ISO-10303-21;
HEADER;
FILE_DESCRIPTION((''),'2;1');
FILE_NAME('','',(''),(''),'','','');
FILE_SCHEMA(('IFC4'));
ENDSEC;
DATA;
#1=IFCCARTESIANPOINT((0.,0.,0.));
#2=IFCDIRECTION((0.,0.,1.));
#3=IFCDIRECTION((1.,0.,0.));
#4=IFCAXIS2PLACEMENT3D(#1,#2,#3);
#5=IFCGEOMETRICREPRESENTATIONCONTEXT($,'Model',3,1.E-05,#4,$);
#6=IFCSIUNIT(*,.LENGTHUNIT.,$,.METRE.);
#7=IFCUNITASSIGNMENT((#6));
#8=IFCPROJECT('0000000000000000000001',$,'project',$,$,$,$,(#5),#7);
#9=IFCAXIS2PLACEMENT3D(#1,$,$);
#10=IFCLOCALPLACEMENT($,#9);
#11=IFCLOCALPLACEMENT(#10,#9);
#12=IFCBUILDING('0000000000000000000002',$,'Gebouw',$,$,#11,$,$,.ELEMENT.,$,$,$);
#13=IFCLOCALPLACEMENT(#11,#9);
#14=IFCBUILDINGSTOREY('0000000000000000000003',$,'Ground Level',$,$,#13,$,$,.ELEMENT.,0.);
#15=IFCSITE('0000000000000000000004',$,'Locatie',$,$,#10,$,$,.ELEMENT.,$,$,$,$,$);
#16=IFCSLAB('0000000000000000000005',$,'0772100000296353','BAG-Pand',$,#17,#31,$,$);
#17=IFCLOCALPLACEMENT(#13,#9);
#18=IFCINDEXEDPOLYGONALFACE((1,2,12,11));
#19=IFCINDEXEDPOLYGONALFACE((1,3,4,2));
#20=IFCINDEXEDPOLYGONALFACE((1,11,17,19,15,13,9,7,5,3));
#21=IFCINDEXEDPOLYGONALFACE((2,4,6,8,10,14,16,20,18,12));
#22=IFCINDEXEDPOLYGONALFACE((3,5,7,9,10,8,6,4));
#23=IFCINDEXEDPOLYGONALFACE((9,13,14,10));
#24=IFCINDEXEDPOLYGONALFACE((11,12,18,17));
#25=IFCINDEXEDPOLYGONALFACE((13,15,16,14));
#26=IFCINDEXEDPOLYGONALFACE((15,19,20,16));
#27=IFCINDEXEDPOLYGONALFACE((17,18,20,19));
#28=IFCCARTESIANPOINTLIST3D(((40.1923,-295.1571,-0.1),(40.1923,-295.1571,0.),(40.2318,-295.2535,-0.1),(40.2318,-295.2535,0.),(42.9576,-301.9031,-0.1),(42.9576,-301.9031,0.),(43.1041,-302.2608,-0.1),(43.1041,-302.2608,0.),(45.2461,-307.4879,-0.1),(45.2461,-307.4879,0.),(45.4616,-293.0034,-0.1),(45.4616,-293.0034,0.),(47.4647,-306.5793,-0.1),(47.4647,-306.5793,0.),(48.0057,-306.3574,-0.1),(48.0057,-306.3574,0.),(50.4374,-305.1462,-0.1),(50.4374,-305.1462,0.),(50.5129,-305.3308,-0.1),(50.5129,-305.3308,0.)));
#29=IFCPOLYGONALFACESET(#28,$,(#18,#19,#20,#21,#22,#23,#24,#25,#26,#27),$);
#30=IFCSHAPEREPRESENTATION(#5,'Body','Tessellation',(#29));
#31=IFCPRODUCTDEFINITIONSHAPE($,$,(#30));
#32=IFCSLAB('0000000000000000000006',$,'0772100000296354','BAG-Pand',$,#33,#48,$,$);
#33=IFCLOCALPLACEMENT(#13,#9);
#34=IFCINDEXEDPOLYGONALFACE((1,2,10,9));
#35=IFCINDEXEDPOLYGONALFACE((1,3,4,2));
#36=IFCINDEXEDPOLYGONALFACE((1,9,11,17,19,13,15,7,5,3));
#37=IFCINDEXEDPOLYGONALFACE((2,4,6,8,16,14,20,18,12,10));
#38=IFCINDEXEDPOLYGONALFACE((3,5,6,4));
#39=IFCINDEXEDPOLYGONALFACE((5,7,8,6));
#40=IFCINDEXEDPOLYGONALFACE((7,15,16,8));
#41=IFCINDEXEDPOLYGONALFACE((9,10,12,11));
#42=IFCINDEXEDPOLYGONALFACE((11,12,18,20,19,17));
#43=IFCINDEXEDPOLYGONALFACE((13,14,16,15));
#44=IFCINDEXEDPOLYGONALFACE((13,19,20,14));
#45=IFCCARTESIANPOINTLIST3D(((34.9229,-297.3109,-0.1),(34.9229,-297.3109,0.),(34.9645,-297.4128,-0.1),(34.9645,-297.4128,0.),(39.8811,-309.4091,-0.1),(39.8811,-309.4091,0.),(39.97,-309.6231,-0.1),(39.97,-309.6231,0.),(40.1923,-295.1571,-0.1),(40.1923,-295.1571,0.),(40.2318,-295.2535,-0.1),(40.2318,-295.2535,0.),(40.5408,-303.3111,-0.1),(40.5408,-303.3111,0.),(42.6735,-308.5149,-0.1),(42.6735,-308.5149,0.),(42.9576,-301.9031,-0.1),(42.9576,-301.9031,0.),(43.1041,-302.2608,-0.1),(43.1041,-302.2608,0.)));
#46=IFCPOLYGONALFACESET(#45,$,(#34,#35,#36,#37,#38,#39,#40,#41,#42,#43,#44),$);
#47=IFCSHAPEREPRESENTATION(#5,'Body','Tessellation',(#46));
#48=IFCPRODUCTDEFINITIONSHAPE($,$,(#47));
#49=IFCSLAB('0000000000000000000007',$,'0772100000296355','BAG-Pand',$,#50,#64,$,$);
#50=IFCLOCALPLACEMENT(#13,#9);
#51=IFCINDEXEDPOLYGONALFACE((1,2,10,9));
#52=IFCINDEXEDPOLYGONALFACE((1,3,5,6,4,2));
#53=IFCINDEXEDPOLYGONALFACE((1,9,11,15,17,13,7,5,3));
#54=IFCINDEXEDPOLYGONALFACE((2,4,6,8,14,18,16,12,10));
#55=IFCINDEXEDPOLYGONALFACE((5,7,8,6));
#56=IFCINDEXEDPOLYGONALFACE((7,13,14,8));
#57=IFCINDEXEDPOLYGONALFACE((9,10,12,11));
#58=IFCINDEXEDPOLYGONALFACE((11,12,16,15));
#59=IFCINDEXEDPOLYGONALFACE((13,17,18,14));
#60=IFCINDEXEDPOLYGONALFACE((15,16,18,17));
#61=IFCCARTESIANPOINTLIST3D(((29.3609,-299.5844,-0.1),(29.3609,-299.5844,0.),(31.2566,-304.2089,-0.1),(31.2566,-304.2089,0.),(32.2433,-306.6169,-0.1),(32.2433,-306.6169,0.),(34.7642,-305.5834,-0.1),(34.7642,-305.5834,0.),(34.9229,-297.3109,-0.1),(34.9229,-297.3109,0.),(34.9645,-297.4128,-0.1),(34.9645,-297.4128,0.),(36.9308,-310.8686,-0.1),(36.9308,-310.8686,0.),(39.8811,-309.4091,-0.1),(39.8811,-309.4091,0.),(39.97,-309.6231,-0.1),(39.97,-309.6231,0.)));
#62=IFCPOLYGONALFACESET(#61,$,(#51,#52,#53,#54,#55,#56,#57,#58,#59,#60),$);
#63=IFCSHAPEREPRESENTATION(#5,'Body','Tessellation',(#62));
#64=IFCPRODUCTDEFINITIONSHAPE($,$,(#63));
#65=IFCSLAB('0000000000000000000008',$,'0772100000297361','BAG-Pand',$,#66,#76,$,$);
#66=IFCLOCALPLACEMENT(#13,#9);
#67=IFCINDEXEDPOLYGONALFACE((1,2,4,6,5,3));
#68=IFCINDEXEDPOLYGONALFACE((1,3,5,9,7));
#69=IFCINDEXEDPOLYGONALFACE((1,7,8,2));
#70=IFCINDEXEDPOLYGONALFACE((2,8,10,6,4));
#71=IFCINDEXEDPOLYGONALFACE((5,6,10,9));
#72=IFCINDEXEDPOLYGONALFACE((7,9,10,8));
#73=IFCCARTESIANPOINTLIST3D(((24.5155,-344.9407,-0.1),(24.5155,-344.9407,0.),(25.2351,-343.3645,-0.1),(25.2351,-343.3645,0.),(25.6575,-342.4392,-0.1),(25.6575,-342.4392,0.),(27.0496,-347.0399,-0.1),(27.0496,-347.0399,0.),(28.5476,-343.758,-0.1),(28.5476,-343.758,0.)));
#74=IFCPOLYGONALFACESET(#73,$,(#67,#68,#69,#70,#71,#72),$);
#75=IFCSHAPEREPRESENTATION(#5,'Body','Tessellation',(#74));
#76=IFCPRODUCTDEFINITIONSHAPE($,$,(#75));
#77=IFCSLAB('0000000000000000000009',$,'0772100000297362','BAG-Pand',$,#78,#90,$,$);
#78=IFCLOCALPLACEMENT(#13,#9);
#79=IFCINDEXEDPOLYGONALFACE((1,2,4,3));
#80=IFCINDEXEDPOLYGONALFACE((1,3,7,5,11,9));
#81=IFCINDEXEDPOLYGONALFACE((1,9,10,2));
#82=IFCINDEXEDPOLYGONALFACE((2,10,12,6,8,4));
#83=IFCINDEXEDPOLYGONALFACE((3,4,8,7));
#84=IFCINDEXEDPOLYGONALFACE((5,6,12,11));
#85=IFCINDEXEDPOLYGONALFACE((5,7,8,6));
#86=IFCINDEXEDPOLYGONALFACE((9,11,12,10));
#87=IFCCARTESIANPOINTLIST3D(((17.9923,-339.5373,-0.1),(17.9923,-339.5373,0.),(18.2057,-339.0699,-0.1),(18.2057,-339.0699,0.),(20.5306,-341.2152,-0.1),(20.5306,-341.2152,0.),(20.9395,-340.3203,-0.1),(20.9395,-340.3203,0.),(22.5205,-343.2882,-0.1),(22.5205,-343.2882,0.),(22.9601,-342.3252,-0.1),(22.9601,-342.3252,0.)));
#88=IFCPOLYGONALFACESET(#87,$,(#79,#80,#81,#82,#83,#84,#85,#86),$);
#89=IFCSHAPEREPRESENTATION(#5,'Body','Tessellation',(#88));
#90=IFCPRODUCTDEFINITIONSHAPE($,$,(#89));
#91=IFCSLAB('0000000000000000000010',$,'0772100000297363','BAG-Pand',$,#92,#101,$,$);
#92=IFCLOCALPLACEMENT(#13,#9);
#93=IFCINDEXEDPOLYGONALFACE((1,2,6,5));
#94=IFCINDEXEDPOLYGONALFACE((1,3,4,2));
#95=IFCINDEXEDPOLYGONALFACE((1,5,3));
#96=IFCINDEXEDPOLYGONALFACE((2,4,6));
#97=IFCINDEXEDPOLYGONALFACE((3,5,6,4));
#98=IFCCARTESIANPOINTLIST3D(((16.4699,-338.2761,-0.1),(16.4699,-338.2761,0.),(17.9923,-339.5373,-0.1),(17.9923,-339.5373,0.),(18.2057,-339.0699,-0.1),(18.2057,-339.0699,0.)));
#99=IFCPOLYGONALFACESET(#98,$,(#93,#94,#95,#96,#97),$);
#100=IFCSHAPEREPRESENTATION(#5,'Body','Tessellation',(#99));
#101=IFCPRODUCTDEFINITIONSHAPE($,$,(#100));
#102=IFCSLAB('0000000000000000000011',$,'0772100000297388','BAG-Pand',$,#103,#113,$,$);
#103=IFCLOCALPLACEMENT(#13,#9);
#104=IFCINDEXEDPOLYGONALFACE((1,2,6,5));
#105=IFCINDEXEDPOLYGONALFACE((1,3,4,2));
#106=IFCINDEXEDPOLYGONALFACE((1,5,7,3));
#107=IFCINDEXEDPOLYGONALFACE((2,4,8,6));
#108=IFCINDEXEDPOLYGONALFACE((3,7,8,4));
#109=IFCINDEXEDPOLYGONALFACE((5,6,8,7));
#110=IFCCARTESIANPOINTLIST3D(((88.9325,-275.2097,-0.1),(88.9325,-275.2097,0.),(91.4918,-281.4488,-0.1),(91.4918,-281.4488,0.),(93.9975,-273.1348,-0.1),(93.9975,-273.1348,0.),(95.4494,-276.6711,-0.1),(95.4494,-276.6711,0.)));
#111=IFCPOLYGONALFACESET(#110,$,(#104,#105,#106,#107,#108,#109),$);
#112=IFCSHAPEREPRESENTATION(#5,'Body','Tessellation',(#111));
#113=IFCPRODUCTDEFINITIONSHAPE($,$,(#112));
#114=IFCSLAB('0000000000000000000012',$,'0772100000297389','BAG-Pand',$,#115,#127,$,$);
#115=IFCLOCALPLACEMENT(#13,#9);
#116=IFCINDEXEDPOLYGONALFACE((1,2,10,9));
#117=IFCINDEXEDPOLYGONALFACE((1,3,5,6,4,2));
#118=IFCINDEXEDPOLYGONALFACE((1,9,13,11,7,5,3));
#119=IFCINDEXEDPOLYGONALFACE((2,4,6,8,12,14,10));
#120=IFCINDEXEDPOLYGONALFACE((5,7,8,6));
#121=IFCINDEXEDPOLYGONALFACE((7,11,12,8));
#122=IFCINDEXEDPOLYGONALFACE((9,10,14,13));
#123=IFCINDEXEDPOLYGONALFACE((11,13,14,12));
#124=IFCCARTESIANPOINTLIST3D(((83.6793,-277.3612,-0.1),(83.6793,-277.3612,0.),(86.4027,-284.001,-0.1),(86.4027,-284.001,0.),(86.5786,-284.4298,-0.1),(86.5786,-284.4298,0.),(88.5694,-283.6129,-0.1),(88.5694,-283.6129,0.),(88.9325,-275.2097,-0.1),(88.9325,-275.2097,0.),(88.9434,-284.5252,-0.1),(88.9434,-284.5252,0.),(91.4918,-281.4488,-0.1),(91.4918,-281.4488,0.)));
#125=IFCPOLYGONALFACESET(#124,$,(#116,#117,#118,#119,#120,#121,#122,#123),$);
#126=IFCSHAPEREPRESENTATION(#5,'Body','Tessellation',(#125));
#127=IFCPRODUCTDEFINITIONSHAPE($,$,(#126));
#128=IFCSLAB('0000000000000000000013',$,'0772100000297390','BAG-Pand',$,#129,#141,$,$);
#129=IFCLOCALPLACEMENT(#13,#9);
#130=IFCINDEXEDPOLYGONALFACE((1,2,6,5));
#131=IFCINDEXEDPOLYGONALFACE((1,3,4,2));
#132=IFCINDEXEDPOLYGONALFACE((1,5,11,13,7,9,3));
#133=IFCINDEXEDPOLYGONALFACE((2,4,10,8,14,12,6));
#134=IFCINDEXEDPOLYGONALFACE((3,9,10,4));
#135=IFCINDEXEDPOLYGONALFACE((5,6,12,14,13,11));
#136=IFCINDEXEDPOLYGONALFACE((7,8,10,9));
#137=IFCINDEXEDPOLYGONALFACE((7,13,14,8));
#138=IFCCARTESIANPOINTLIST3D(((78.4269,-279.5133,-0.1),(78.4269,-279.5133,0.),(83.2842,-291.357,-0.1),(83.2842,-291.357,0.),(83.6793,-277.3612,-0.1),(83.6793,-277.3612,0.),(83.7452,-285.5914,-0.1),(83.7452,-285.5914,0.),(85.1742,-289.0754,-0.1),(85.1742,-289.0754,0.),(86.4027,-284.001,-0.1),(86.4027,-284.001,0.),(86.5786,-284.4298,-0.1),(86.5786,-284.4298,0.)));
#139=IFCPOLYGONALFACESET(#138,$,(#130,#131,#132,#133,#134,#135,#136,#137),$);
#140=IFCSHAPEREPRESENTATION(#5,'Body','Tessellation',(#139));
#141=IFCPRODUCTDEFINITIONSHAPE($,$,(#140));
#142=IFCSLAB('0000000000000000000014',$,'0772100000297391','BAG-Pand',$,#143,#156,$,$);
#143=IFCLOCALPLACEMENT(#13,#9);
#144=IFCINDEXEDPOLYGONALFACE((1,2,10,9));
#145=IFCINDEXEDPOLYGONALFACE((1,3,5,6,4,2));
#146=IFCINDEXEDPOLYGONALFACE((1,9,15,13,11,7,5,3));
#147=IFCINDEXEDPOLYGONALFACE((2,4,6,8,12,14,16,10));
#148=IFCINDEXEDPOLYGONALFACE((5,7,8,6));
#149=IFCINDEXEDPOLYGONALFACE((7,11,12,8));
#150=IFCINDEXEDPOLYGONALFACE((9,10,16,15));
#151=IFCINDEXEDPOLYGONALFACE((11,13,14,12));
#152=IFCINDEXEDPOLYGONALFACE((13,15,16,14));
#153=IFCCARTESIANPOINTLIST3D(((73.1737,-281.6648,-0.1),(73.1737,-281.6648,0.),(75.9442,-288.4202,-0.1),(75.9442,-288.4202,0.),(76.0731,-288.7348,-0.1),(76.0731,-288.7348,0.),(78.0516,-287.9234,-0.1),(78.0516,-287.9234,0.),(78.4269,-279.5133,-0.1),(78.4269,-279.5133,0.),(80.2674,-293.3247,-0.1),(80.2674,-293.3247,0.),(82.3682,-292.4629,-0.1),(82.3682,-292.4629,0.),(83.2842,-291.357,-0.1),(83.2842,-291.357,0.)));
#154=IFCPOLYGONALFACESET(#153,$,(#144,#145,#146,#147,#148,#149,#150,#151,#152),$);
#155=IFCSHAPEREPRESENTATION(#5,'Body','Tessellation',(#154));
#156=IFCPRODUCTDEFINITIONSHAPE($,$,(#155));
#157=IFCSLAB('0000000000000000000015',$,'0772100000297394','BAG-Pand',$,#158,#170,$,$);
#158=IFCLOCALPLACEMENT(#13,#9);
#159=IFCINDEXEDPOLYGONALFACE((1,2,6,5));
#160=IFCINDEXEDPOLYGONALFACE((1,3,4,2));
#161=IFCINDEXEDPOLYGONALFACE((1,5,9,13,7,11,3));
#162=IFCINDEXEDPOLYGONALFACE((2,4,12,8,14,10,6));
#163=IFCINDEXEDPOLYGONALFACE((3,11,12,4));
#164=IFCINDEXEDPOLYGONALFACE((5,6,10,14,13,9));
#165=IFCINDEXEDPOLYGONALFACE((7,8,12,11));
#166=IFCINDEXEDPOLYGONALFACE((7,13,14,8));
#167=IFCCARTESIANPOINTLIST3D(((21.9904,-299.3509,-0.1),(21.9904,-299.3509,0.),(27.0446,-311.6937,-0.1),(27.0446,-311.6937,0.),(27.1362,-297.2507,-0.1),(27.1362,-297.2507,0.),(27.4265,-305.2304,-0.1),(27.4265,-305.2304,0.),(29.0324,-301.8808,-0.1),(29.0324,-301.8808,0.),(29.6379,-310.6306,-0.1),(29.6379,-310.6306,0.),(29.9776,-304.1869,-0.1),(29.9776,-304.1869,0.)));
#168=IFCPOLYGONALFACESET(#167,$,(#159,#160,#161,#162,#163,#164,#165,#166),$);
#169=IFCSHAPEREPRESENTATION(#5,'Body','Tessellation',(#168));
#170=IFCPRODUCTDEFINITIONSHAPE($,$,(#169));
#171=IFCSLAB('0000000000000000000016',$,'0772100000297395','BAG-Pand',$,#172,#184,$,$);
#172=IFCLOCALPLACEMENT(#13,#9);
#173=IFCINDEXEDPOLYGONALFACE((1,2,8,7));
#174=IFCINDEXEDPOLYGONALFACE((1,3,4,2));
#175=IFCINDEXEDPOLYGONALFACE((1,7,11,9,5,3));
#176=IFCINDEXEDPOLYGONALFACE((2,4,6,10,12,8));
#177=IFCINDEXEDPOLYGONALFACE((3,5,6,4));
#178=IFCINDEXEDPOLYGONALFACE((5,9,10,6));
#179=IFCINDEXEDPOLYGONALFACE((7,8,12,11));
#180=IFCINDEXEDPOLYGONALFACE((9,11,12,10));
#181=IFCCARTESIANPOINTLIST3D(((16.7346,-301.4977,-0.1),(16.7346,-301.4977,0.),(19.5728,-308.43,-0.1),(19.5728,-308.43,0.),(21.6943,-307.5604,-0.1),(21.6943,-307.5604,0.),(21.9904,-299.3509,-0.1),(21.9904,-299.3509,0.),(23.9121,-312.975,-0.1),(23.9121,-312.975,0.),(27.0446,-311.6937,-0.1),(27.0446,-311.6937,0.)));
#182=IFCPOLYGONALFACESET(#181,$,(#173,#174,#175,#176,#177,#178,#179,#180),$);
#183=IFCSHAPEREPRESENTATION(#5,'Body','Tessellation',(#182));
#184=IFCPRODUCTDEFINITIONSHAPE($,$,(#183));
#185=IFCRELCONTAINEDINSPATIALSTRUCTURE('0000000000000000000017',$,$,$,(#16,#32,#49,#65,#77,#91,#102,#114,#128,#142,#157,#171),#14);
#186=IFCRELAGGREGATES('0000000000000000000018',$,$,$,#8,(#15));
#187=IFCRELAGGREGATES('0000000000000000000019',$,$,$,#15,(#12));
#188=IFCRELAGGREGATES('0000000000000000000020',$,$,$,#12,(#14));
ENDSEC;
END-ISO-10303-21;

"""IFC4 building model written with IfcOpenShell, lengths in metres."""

from ifc_helpers import new_model, si_unit, frame, origin, origin_with_axes, place, context, project, spatial, polyline, outline, extrude, element, save


model = new_model("IFC4")

# Units and contexts
model_context = context("Model", 3, precision=1e-05, world=origin_with_axes())
ifc_project = project(units=[si_unit("LENGTHUNIT", "METRE")], contexts=[model_context])

# Site, building, storey
site_placement = place(None, origin())
site = spatial("IfcSite", under=ifc_project, at=site_placement, Name="Locatie", CompositionType="ELEMENT")
building_placement = place(site_placement, origin())
building = spatial("IfcBuilding", under=site, at=building_placement, Name="Gebouw", CompositionType="ELEMENT")
storey_placement = place(building_placement, origin())
storey = spatial("IfcBuildingStorey", under=building, at=storey_placement, Name="Ground Level", CompositionType="ELEMENT", Elevation=0.0)

# Slabs
slab_1_placement = place(storey_placement, origin())
element("IfcSlab", 1, at=slab_1_placement, inside=storey, Name="0772100000296353", Description="BAG-Pand", context=model_context, shape_type="SweptSolid", body=[
    extrude(outline(polyline([(43.1041, -302.2608), (42.9576, -301.9031), (40.2318, -295.2535), (40.1923, -295.1571), (45.4616, -293.0034), (50.4374, -305.1462), (50.5129, -305.3308), (48.0057, -306.3574), (47.4647, -306.5793), (45.2461, -307.4879), (43.1041, -302.2608)])), frame((0.0, 0.0, -0.1), z_axis=(0.0, 0.0, 1.0), x_axis=(1.0, 0.0, 0.0)), (0.0, 0.0, 1.0), 0.1),
])
slab_2_placement = place(storey_placement, origin())
element("IfcSlab", 2, at=slab_2_placement, inside=storey, Name="0772100000296354", Description="BAG-Pand", context=model_context, shape_type="SweptSolid", body=[
    extrude(outline(polyline([(39.97, -309.6231), (39.8811, -309.4091), (34.9645, -297.4128), (34.9229, -297.3109), (40.1923, -295.1571), (40.2318, -295.2535), (42.9576, -301.9031), (43.1041, -302.2608), (40.5408, -303.3111), (42.6735, -308.5149), (39.97, -309.6231)])), frame((0.0, 0.0, -0.1), z_axis=(0.0, 0.0, 1.0), x_axis=(1.0, 0.0, 0.0)), (0.0, 0.0, 1.0), 0.1),
])
slab_3_placement = place(storey_placement, origin())
element("IfcSlab", 3, at=slab_3_placement, inside=storey, Name="0772100000296355", Description="BAG-Pand", context=model_context, shape_type="SweptSolid", body=[
    extrude(outline(polyline([(34.9229, -297.3109), (34.9645, -297.4128), (39.8811, -309.4091), (39.97, -309.6231), (36.9308, -310.8686), (34.7642, -305.5834), (32.2433, -306.6169), (31.2566, -304.2089), (29.3609, -299.5844), (34.9229, -297.3109)])), frame((0.0, 0.0, -0.1), z_axis=(0.0, 0.0, 1.0), x_axis=(1.0, 0.0, 0.0)), (0.0, 0.0, 1.0), 0.1),
])
slab_4_placement = place(storey_placement, origin())
element("IfcSlab", 4, at=slab_4_placement, inside=storey, Name="0772100000297361", Description="BAG-Pand", context=model_context, shape_type="SweptSolid", body=[
    extrude(outline(polyline([(25.2351, -343.3645), (25.6575, -342.4392), (28.5476, -343.758), (27.0496, -347.0399), (24.5155, -344.9407), (25.2351, -343.3645)])), frame((0.0, 0.0, -0.1), z_axis=(0.0, 0.0, 1.0), x_axis=(1.0, 0.0, 0.0)), (0.0, 0.0, 1.0), 0.1),
])
slab_5_placement = place(storey_placement, origin())
element("IfcSlab", 5, at=slab_5_placement, inside=storey, Name="0772100000297362", Description="BAG-Pand", context=model_context, shape_type="SweptSolid", body=[
    extrude(outline(polyline([(18.2057, -339.0699), (20.9395, -340.3203), (20.5306, -341.2152), (22.9601, -342.3252), (22.5205, -343.2882), (17.9923, -339.5373), (18.2057, -339.0699)])), frame((0.0, 0.0, -0.1), z_axis=(0.0, 0.0, 1.0), x_axis=(1.0, 0.0, 0.0)), (0.0, 0.0, 1.0), 0.1),
])
slab_6_placement = place(storey_placement, origin())
element("IfcSlab", 6, at=slab_6_placement, inside=storey, Name="0772100000297363", Description="BAG-Pand", context=model_context, shape_type="SweptSolid", body=[
    extrude(outline(polyline([(18.2057, -339.0699), (17.9923, -339.5373), (16.4699, -338.2761), (18.2057, -339.0699)])), frame((0.0, 0.0, -0.1), z_axis=(0.0, 0.0, 1.0), x_axis=(1.0, 0.0, 0.0)), (0.0, 0.0, 1.0), 0.1),
])
slab_7_placement = place(storey_placement, origin())
element("IfcSlab", 7, at=slab_7_placement, inside=storey, Name="0772100000297388", Description="BAG-Pand", context=model_context, shape_type="SweptSolid", body=[
    extrude(outline(polyline([(88.9325, -275.2097), (93.9975, -273.1348), (95.4494, -276.6711), (91.4918, -281.4488), (88.9325, -275.2097)])), frame((0.0, 0.0, -0.1), z_axis=(0.0, 0.0, 1.0), x_axis=(1.0, 0.0, 0.0)), (0.0, 0.0, 1.0), 0.1),
])
slab_8_placement = place(storey_placement, origin())
element("IfcSlab", 8, at=slab_8_placement, inside=storey, Name="0772100000297389", Description="BAG-Pand", context=model_context, shape_type="SweptSolid", body=[
    extrude(outline(polyline([(88.5694, -283.6129), (86.5786, -284.4298), (86.4027, -284.001), (83.6793, -277.3612), (88.9325, -275.2097), (91.4918, -281.4488), (88.9434, -284.5252), (88.5694, -283.6129)])), frame((0.0, 0.0, -0.1), z_axis=(0.0, 0.0, 1.0), x_axis=(1.0, 0.0, 0.0)), (0.0, 0.0, 1.0), 0.1),
])
slab_9_placement = place(storey_placement, origin())
element("IfcSlab", 9, at=slab_9_placement, inside=storey, Name="0772100000297390", Description="BAG-Pand", context=model_context, shape_type="SweptSolid", body=[
    extrude(outline(polyline([(78.4269, -279.5133), (83.6793, -277.3612), (86.4027, -284.001), (86.5786, -284.4298), (83.7452, -285.5914), (85.1742, -289.0754), (83.2842, -291.357), (78.4269, -279.5133)])), frame((0.0, 0.0, -0.1), z_axis=(0.0, 0.0, 1.0), x_axis=(1.0, 0.0, 0.0)), (0.0, 0.0, 1.0), 0.1),
])
slab_10_placement = place(storey_placement, origin())
element("IfcSlab", 10, at=slab_10_placement, inside=storey, Name="0772100000297391", Description="BAG-Pand", context=model_context, shape_type="SweptSolid", body=[
    extrude(outline(polyline([(80.2674, -293.3247), (78.0516, -287.9234), (76.0731, -288.7348), (75.9442, -288.4202), (73.1737, -281.6648), (78.4269, -279.5133), (83.2842, -291.357), (82.3682, -292.4629), (80.2674, -293.3247)])), frame((0.0, 0.0, -0.1), z_axis=(0.0, 0.0, 1.0), x_axis=(1.0, 0.0, 0.0)), (0.0, 0.0, 1.0), 0.1),
])
slab_11_placement = place(storey_placement, origin())
element("IfcSlab", 11, at=slab_11_placement, inside=storey, Name="0772100000297394", Description="BAG-Pand", context=model_context, shape_type="SweptSolid", body=[
    extrude(outline(polyline([(27.1362, -297.2507), (29.0324, -301.8808), (29.9776, -304.1869), (27.4265, -305.2304), (29.6379, -310.6306), (27.0446, -311.6937), (21.9904, -299.3509), (27.1362, -297.2507)])), frame((0.0, 0.0, -0.1), z_axis=(0.0, 0.0, 1.0), x_axis=(1.0, 0.0, 0.0)), (0.0, 0.0, 1.0), 0.1),
])
slab_12_placement = place(storey_placement, origin())
element("IfcSlab", 12, at=slab_12_placement, inside=storey, Name="0772100000297395", Description="BAG-Pand", context=model_context, shape_type="SweptSolid", body=[
    extrude(outline(polyline([(21.6943, -307.5604), (19.5728, -308.43), (16.7346, -301.4977), (21.9904, -299.3509), (27.0446, -311.6937), (23.9121, -312.975), (21.6943, -307.5604)])), frame((0.0, 0.0, -0.1), z_axis=(0.0, 0.0, 1.0), x_axis=(1.0, 0.0, 0.0)), (0.0, 0.0, 1.0), 0.1),
])

save(model, "model.ifc")
